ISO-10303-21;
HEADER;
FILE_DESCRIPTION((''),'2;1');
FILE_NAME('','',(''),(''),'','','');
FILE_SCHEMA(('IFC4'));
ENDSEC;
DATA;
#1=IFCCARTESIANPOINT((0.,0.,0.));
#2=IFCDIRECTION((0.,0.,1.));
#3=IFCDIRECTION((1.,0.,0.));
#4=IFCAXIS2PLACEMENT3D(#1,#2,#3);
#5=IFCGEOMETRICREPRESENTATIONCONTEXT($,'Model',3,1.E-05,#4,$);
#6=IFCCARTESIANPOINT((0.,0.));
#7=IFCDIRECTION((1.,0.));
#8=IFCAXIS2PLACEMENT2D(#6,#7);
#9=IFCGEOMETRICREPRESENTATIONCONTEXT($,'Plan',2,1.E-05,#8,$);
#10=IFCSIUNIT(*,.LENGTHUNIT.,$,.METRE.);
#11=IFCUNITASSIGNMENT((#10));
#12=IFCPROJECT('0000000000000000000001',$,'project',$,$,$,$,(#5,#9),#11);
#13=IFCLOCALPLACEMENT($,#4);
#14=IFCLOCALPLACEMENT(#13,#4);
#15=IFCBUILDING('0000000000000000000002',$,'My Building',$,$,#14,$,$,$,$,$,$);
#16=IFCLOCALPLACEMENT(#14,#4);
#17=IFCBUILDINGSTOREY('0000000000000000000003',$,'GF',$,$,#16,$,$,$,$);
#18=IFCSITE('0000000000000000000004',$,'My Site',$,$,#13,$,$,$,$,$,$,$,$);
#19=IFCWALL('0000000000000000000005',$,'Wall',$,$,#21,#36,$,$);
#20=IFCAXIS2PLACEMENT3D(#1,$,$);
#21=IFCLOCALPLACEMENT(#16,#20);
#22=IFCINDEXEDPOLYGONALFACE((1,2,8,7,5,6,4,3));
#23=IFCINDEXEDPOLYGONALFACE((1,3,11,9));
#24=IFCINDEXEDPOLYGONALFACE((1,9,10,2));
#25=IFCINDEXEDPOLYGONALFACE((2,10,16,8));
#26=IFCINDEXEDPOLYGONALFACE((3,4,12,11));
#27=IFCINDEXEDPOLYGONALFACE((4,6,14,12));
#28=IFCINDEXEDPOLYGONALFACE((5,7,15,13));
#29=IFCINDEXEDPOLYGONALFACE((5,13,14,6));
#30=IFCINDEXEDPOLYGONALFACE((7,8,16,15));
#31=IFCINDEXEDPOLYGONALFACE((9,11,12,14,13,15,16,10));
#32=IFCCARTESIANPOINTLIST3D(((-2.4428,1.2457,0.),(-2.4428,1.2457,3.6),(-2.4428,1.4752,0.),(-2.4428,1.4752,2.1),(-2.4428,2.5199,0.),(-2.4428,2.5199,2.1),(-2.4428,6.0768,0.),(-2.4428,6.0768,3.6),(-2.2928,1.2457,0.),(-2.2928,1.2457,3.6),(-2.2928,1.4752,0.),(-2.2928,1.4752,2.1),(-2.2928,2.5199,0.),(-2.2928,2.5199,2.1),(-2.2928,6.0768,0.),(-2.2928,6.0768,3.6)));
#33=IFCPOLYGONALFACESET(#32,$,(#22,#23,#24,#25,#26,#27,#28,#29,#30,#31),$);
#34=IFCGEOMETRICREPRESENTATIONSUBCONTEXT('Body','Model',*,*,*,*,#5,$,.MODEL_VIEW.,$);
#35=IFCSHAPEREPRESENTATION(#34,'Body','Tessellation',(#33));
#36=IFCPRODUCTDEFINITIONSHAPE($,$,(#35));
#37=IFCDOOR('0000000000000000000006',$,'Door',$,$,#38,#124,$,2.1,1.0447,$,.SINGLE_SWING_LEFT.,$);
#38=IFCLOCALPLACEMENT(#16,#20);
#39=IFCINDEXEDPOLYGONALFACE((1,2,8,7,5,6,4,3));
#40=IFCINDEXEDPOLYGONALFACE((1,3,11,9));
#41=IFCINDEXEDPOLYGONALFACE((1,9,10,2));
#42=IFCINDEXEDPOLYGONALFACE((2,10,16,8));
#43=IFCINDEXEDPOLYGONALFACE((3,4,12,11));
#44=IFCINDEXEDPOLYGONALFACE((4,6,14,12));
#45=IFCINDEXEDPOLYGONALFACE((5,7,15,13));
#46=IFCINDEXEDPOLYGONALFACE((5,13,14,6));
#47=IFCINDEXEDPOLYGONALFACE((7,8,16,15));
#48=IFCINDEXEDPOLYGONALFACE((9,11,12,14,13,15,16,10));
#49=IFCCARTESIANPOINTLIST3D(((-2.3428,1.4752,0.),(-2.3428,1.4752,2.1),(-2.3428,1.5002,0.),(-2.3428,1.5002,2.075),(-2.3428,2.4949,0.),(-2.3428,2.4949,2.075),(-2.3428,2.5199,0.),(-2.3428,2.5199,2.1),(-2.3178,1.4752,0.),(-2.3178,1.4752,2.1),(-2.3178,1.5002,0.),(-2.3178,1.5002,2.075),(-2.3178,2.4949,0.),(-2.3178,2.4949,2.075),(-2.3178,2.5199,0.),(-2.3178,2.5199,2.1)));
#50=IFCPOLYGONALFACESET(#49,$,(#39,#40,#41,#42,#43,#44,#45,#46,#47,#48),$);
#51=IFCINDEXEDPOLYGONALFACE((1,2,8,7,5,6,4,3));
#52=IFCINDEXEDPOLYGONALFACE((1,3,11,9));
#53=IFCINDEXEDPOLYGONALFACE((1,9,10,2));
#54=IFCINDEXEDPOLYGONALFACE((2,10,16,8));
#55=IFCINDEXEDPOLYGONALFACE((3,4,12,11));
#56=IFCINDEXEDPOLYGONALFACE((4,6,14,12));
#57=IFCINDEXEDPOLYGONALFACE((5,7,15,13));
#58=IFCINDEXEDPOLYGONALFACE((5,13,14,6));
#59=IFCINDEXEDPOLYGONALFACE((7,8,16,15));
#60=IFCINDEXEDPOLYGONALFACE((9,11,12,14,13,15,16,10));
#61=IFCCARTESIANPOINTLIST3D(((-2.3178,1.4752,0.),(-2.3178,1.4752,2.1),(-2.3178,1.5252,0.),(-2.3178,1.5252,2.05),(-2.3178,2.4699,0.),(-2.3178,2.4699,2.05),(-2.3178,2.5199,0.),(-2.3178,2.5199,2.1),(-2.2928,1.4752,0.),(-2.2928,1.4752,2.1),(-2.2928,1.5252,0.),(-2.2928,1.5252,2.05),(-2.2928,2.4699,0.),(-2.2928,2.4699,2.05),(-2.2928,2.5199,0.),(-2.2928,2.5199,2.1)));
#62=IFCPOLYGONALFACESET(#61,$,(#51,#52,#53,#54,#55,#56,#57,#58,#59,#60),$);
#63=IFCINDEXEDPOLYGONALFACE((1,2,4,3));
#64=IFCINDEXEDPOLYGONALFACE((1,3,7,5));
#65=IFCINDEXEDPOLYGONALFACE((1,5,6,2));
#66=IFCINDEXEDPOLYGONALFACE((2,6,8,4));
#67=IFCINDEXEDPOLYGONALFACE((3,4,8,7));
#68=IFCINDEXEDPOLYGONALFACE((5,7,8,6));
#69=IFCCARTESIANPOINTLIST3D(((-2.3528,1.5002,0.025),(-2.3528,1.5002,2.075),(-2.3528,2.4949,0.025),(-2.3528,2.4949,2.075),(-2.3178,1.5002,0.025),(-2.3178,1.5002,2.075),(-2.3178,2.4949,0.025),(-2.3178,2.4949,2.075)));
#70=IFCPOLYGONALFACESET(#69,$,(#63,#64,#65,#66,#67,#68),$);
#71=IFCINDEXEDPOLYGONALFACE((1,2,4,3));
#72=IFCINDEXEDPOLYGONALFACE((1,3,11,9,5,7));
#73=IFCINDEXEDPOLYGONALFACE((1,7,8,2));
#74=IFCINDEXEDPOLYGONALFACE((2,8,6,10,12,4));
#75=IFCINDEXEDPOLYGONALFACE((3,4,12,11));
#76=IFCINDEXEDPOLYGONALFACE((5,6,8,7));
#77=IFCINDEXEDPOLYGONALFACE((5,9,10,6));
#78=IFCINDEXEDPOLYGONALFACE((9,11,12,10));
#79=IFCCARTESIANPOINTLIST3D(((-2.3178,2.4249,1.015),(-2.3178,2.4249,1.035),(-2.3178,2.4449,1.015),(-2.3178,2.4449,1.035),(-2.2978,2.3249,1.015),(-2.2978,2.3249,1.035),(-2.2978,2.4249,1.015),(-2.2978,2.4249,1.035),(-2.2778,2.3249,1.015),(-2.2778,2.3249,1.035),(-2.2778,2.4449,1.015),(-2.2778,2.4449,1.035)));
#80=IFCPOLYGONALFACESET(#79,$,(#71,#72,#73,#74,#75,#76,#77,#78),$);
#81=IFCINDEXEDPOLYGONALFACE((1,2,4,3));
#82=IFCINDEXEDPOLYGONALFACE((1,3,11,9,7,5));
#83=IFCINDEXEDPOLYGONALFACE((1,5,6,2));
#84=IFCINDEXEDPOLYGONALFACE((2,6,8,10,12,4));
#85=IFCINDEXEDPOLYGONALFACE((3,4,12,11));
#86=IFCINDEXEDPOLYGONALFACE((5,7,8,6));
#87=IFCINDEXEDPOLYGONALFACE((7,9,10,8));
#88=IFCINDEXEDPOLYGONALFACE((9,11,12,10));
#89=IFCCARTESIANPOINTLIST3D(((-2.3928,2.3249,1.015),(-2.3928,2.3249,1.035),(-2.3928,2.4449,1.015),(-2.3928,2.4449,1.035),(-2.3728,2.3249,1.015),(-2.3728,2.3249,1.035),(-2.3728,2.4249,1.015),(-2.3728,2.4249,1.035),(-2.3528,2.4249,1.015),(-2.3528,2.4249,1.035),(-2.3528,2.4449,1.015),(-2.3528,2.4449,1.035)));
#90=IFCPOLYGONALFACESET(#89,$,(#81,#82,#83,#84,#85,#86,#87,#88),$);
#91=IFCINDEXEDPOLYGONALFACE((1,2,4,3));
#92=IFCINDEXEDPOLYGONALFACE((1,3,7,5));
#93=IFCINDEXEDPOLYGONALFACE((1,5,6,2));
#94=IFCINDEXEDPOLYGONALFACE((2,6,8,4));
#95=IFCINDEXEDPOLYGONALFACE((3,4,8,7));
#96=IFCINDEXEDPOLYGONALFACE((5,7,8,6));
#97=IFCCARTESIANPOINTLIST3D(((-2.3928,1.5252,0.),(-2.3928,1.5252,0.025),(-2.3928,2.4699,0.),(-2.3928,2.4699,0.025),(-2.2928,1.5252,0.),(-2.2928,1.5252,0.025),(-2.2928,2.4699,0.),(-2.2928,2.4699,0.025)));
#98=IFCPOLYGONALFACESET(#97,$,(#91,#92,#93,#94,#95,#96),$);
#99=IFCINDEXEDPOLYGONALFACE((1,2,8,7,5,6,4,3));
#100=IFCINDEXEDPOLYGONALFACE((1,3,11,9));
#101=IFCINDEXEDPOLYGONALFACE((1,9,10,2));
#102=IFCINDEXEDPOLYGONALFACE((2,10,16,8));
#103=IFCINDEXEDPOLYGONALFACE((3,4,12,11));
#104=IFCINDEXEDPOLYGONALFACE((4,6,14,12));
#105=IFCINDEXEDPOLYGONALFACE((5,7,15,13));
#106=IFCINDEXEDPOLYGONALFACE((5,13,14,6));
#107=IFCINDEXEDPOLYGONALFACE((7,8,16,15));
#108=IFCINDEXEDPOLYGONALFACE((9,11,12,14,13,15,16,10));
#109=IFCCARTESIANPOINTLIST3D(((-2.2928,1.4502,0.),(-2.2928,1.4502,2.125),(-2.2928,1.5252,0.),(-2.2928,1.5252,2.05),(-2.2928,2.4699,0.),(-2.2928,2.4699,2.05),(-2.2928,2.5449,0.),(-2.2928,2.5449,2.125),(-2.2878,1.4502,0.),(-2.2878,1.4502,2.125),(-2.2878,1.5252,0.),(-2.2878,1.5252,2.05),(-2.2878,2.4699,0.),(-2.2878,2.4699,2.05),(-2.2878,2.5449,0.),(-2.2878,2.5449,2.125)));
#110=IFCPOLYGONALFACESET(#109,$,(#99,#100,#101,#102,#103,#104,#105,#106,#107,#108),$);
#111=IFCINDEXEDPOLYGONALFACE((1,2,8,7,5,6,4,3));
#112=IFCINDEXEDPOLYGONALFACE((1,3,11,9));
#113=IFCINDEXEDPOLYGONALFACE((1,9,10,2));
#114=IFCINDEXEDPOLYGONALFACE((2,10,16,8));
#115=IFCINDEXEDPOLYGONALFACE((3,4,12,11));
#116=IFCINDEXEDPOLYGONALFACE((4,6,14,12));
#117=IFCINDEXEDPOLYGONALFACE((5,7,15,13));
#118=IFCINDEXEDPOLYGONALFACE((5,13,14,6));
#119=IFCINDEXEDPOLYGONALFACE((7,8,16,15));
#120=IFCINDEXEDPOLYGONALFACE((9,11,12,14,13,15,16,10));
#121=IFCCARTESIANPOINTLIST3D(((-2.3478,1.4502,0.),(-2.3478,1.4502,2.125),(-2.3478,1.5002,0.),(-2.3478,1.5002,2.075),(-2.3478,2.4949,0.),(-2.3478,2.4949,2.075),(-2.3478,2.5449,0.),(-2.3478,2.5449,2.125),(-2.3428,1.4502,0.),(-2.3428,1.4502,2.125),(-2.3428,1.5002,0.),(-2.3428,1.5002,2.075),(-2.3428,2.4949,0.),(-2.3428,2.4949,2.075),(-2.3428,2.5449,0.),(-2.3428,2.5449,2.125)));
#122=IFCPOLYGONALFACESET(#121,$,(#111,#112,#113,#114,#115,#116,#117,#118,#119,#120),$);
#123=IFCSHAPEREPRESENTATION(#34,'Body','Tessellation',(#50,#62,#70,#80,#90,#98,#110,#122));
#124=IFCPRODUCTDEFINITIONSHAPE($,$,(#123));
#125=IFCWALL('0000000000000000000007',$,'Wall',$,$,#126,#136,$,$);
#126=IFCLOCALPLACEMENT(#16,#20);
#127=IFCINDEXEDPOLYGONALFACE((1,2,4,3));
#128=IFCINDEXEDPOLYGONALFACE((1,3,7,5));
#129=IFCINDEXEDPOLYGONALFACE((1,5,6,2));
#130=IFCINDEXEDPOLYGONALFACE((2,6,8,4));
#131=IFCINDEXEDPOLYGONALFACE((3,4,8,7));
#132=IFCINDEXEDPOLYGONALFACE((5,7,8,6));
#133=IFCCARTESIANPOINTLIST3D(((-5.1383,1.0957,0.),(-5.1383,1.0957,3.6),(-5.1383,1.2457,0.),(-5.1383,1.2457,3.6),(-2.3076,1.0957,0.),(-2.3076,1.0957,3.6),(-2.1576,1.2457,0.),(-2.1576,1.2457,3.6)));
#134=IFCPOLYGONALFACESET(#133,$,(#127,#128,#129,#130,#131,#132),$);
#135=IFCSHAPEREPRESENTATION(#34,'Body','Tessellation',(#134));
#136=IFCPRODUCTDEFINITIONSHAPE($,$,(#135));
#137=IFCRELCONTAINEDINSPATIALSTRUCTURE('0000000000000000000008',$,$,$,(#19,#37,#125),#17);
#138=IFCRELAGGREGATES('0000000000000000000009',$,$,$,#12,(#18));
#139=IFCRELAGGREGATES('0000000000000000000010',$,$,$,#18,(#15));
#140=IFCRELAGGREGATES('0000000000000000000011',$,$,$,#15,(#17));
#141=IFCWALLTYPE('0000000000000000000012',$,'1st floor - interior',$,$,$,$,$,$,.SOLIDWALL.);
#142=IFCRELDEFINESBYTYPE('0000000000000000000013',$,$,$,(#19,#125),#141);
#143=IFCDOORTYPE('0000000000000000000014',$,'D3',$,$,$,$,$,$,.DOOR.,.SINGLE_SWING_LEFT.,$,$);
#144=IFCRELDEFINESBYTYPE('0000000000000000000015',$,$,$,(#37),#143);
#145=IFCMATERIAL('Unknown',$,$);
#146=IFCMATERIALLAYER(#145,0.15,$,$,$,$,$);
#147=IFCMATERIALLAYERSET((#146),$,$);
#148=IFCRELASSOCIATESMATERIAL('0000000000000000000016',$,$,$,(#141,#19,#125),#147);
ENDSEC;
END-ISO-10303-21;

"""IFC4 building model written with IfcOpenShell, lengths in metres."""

from ifc_helpers import new_model, entity, si_unit, frame, origin_with_axes, origin_2d_with_axis, place, context, subcontext, project, spatial, line, indexed_curve, outline, extrude, shape, source, transform, mapped, material, layer, layer_set, layer_usage, type_object, type_shapes, element, fill, save


model = new_model("IFC4")

# Units and contexts
model_context = context("Model", 3, precision=1e-05, world=origin_with_axes())
plan_context = context("Plan", 2, precision=1e-05, world=origin_2d_with_axis())
body_context_1 = subcontext(model_context, "Body", "Model", "MODEL_VIEW")
body_context_2 = subcontext(plan_context, "Body", "Plan", "PLAN_VIEW")
ifc_project = project(units=[si_unit("LENGTHUNIT", "METRE")], contexts=[model_context, plan_context])

# Site, building, storey
site_placement = place(None, origin_with_axes())
site = spatial("IfcSite", under=ifc_project, at=site_placement, Name="My Site")
building_placement = place(site_placement, origin_with_axes())
building = spatial("IfcBuilding", under=site, at=building_placement, Name="My Building")
storey_placement = place(building_placement, origin_with_axes())
storey = spatial("IfcBuildingStorey", under=building, at=storey_placement, Name="GF")

# Shared definitions
ifc_material = material(Name="Unknown")

# Wall, opening, door
ifc_layer_1 = layer(ifc_material, 0.15)
ifc_layer_set_1 = layer_set([ifc_layer_1])
ifc_layer_usage_1 = layer_usage(ifc_layer_set_1, "AXIS2", "POSITIVE", 0.0)
wall_type_1 = type_object("IfcWallType", Name="1st floor - interior", PredefinedType="SOLIDWALL", material=ifc_layer_set_1)
wall_1_placement = place(storey_placement, frame((-2.4428, 6.0768, 0.0), z_axis=(0.0, 0.0, 1.0), x_axis=(0.0, -1.0, 0.0)))
wall_1 = element("IfcWall", 1, at=wall_1_placement, inside=storey, type_object=wall_type_1, material=ifc_layer_usage_1, Name="Wall", context=body_context_1, shape_type="SweptSolid", body=[
    extrude(outline(indexed_curve([(0.0, 0.0), (0.0, 0.15), (4.8311, 0.15), (4.8311, 0.0)], segments=[line(1, 2, 3, 4, 1)])), origin_with_axes(), (0.0, 0.0, 1.0), 3.6),
])
shared_shape_1 = source(origin_with_axes(), body_context_1, "Body", "SweptSolid", [
    extrude(outline(indexed_curve([(0.0, 0.0), (1.0447, 0.0), (1.0447, 2.1), (0.0, 2.1)], segments=[line(1, 2, 3, 4, 1)])), frame((0.0, -0.6, 0.0), z_axis=(0.0, -1.0, 0.0), x_axis=(1.0, 0.0, 0.0)), (0.0, 0.0, -1.0), 1.2),
])
opening_1_placement = place(wall_1_placement, frame((4.6015, 0.15, 0.0), z_axis=(0.0, 0.0, 1.0), x_axis=(-1.0, 0.0, 0.0)))
opening_1 = element("IfcOpeningElement", 2, at=opening_1_placement, cuts=wall_1, PredefinedType="OPENING", context=body_context_1, shape_type="MappedRepresentation", body=[
    mapped(shared_shape_1, transform((0.0, 0.0, 0.0), x_axis=(1.0, 0.0, 0.0), y_axis=(0.0, 1.0, 0.0), z_axis=(0.0, 0.0, 1.0), scale=1.0)),
])
door_type_1 = type_object("IfcDoorType", Name="D3", OperationType="SINGLE_SWING_LEFT", PredefinedType="DOOR")
shared_shape_2 = source(origin_with_axes(), body_context_1, "Body", "SweptSolid", [
    extrude(outline(indexed_curve([(0.0, 0.0), (0.0, 2.1), (1.0447, 2.1), (1.0447, 0.0), (1.0197, 0.0), (1.0197, 2.075), (0.025, 2.075), (0.025, 0.0)], segments=[line(1, 2, 3, 4, 5, 6, 7, 8, 1)])), frame((0.0, 0.025, 0.0), z_axis=(0.0, -1.0, 0.0), x_axis=(1.0, 0.0, 0.0)), (0.0, 0.0, -1.0), 0.025),
    extrude(outline(indexed_curve([(0.0, 0.0), (0.0, 2.1), (1.0447, 2.1), (1.0447, 0.0), (0.9947, 0.0), (0.9947, 2.05), (0.05, 2.05), (0.05, 0.0)], segments=[line(1, 2, 3, 4, 5, 6, 7, 8, 1)])), frame((0.0, 0.0, 0.0), z_axis=(0.0, -1.0, 0.0), x_axis=(1.0, 0.0, 0.0)), (0.0, 0.0, -1.0), 0.025),
    extrude(outline(indexed_curve([(0.0, 0.0), (0.9947, 0.0), (0.9947, 0.035), (0.0, 0.035)], segments=[line(1, 2, 3, 4, 1)])), frame((0.025, 0.025, 0.025), z_axis=(0.0, 0.0, 1.0), x_axis=(1.0, 0.0, 0.0)), (0.0, 0.0, 1.0), 2.05),
    extrude(outline(indexed_curve([(0.0, 0.0), (0.0, -0.04), (-0.12, -0.04), (-0.12, -0.02), (-0.02, -0.02), (-0.02, 0.0)], segments=[line(1, 2, 3, 4, 5, 6, 1)])), frame((0.9697, 0.025, 1.015), z_axis=(0.0, 0.0, 1.0), x_axis=(1.0, 0.0, 0.0)), (0.0, 0.0, 1.0), 0.02),
    extrude(outline(indexed_curve([(0.0, 0.0), (0.0, 0.04), (-0.12, 0.04), (-0.12, 0.02), (-0.02, 0.02), (-0.02, 0.0)], segments=[line(1, 2, 3, 4, 5, 6, 1)])), frame((0.9697, 0.06, 1.015), z_axis=(0.0, 0.0, 1.0), x_axis=(1.0, 0.0, 0.0)), (0.0, 0.0, 1.0), 0.02),
    extrude(outline(indexed_curve([(0.0, 0.0), (0.9447, 0.0), (0.9447, 0.1), (0.0, 0.1)], segments=[line(1, 2, 3, 4, 1)])), frame((0.05, 0.0, 0.0), z_axis=(0.0, 0.0, 1.0), x_axis=(1.0, 0.0, 0.0)), (0.0, 0.0, 1.0), 0.025),
    extrude(outline(indexed_curve([(0.0, 0.0), (0.0, 2.125), (1.0947, 2.125), (1.0947, 0.0), (1.0197, 0.0), (1.0197, 2.05), (0.075, 2.05), (0.075, 0.0)], segments=[line(1, 2, 3, 4, 5, 6, 7, 8, 1)])), frame((-0.025, -0.005, 0.0), z_axis=(0.0, -1.0, 0.0), x_axis=(1.0, 0.0, 0.0)), (0.0, 0.0, -1.0), 0.005),
    extrude(outline(indexed_curve([(0.0, 0.0), (0.0, 2.125), (1.0947, 2.125), (1.0947, 0.0), (1.0447, 0.0), (1.0447, 2.075), (0.05, 2.075), (0.05, 0.0)], segments=[line(1, 2, 3, 4, 5, 6, 7, 8, 1)])), frame((-0.025, 0.05, 0.0), z_axis=(0.0, -1.0, 0.0), x_axis=(1.0, 0.0, 0.0)), (0.0, 0.0, -1.0), 0.005),
])
shared_shape_3 = source(origin_with_axes(), body_context_2, "Body", "Curve2D", [
    entity("IfcIndexedPolyCurve", entity("IfcCartesianPointList2D", [[0.0, 0.0], [0.0, 0.05], [0.025, 0.05], [0.025, 0.025], [0.05, 0.025], [0.05, 0.0]]), [entity("IfcLineIndex", [1, 2, 3, 4, 5, 6, 1])]),
    entity("IfcIndexedPolyCurve", entity("IfcCartesianPointList2D", [[1.0447, 0.0], [1.0447, 0.05], [1.0197, 0.05], [1.0197, 0.025], [0.9947, 0.025], [0.9947, 0.0]]), [entity("IfcLineIndex", [1, 2, 3, 4, 5, 6, 1])]),
    entity("IfcTrimmedCurve", entity("IfcEllipse", entity("IfcAxis2Placement2D", entity("IfcCartesianPoint", [0.06, 0.05]), entity("IfcDirection", [1.0, 0.0])), 0.9597, 0.9947), [entity("IfcCartesianPoint", [1.0197, 0.05])], [entity("IfcCartesianPoint", [0.06, 1.0447])], True, "CARTESIAN"),
    entity("IfcIndexedPolyCurve", entity("IfcCartesianPointList2D", [[0.025, 0.05], [0.06, 0.05], [0.06, 1.0447], [0.025, 1.0447]]), [entity("IfcLineIndex", [1, 2, 3, 4, 1])]),
])
type_shapes(door_type_1, [shared_shape_2, shared_shape_3])
door_1_placement = place(opening_1_placement, origin_with_axes())
door_1 = element("IfcDoor", 3, at=door_1_placement, inside=storey, type_object=door_type_1, Name="Door", OperationType="SINGLE_SWING_LEFT", OverallHeight=2.1, OverallWidth=1.0447, shapes=[
    shape(body_context_1, "Body", "MappedRepresentation", [mapped(shared_shape_2, transform((0.0, 0.0, 0.0), x_axis=(1.0, 0.0, 0.0), y_axis=(0.0, 1.0, 0.0), z_axis=(0.0, 0.0, 1.0), scale=1.0))]),
    shape(body_context_2, "Body", "MappedRepresentation", [mapped(shared_shape_3, transform((0.0, 0.0, 0.0), x_axis=(1.0, 0.0, 0.0), y_axis=(0.0, 1.0, 0.0), z_axis=(0.0, 0.0, 1.0), scale=1.0))]),
])
fill(opening_1, door_1)

# Wall
ifc_layer_usage_2 = layer_usage(ifc_layer_set_1, "AXIS2", "POSITIVE", 0.0)
wall_2_placement = place(storey_placement, frame((-5.1383, 1.0957, 0.0), z_axis=(0.0, 0.0, 1.0), x_axis=(1.0, 0.0, 0.0)))
element("IfcWall", 4, at=wall_2_placement, inside=storey, type_object=wall_type_1, material=ifc_layer_usage_2, Name="Wall", context=body_context_1, shape_type="SweptSolid", body=[
    extrude(outline(indexed_curve([(0.0, 0.0), (0.0, 0.15), (2.9806, 0.15), (2.8306, 0.0)], segments=[line(1, 2, 3, 4, 1)])), origin_with_axes(), (0.0, 0.0, 1.0), 3.6),
])

save(model, "model.ifc")
